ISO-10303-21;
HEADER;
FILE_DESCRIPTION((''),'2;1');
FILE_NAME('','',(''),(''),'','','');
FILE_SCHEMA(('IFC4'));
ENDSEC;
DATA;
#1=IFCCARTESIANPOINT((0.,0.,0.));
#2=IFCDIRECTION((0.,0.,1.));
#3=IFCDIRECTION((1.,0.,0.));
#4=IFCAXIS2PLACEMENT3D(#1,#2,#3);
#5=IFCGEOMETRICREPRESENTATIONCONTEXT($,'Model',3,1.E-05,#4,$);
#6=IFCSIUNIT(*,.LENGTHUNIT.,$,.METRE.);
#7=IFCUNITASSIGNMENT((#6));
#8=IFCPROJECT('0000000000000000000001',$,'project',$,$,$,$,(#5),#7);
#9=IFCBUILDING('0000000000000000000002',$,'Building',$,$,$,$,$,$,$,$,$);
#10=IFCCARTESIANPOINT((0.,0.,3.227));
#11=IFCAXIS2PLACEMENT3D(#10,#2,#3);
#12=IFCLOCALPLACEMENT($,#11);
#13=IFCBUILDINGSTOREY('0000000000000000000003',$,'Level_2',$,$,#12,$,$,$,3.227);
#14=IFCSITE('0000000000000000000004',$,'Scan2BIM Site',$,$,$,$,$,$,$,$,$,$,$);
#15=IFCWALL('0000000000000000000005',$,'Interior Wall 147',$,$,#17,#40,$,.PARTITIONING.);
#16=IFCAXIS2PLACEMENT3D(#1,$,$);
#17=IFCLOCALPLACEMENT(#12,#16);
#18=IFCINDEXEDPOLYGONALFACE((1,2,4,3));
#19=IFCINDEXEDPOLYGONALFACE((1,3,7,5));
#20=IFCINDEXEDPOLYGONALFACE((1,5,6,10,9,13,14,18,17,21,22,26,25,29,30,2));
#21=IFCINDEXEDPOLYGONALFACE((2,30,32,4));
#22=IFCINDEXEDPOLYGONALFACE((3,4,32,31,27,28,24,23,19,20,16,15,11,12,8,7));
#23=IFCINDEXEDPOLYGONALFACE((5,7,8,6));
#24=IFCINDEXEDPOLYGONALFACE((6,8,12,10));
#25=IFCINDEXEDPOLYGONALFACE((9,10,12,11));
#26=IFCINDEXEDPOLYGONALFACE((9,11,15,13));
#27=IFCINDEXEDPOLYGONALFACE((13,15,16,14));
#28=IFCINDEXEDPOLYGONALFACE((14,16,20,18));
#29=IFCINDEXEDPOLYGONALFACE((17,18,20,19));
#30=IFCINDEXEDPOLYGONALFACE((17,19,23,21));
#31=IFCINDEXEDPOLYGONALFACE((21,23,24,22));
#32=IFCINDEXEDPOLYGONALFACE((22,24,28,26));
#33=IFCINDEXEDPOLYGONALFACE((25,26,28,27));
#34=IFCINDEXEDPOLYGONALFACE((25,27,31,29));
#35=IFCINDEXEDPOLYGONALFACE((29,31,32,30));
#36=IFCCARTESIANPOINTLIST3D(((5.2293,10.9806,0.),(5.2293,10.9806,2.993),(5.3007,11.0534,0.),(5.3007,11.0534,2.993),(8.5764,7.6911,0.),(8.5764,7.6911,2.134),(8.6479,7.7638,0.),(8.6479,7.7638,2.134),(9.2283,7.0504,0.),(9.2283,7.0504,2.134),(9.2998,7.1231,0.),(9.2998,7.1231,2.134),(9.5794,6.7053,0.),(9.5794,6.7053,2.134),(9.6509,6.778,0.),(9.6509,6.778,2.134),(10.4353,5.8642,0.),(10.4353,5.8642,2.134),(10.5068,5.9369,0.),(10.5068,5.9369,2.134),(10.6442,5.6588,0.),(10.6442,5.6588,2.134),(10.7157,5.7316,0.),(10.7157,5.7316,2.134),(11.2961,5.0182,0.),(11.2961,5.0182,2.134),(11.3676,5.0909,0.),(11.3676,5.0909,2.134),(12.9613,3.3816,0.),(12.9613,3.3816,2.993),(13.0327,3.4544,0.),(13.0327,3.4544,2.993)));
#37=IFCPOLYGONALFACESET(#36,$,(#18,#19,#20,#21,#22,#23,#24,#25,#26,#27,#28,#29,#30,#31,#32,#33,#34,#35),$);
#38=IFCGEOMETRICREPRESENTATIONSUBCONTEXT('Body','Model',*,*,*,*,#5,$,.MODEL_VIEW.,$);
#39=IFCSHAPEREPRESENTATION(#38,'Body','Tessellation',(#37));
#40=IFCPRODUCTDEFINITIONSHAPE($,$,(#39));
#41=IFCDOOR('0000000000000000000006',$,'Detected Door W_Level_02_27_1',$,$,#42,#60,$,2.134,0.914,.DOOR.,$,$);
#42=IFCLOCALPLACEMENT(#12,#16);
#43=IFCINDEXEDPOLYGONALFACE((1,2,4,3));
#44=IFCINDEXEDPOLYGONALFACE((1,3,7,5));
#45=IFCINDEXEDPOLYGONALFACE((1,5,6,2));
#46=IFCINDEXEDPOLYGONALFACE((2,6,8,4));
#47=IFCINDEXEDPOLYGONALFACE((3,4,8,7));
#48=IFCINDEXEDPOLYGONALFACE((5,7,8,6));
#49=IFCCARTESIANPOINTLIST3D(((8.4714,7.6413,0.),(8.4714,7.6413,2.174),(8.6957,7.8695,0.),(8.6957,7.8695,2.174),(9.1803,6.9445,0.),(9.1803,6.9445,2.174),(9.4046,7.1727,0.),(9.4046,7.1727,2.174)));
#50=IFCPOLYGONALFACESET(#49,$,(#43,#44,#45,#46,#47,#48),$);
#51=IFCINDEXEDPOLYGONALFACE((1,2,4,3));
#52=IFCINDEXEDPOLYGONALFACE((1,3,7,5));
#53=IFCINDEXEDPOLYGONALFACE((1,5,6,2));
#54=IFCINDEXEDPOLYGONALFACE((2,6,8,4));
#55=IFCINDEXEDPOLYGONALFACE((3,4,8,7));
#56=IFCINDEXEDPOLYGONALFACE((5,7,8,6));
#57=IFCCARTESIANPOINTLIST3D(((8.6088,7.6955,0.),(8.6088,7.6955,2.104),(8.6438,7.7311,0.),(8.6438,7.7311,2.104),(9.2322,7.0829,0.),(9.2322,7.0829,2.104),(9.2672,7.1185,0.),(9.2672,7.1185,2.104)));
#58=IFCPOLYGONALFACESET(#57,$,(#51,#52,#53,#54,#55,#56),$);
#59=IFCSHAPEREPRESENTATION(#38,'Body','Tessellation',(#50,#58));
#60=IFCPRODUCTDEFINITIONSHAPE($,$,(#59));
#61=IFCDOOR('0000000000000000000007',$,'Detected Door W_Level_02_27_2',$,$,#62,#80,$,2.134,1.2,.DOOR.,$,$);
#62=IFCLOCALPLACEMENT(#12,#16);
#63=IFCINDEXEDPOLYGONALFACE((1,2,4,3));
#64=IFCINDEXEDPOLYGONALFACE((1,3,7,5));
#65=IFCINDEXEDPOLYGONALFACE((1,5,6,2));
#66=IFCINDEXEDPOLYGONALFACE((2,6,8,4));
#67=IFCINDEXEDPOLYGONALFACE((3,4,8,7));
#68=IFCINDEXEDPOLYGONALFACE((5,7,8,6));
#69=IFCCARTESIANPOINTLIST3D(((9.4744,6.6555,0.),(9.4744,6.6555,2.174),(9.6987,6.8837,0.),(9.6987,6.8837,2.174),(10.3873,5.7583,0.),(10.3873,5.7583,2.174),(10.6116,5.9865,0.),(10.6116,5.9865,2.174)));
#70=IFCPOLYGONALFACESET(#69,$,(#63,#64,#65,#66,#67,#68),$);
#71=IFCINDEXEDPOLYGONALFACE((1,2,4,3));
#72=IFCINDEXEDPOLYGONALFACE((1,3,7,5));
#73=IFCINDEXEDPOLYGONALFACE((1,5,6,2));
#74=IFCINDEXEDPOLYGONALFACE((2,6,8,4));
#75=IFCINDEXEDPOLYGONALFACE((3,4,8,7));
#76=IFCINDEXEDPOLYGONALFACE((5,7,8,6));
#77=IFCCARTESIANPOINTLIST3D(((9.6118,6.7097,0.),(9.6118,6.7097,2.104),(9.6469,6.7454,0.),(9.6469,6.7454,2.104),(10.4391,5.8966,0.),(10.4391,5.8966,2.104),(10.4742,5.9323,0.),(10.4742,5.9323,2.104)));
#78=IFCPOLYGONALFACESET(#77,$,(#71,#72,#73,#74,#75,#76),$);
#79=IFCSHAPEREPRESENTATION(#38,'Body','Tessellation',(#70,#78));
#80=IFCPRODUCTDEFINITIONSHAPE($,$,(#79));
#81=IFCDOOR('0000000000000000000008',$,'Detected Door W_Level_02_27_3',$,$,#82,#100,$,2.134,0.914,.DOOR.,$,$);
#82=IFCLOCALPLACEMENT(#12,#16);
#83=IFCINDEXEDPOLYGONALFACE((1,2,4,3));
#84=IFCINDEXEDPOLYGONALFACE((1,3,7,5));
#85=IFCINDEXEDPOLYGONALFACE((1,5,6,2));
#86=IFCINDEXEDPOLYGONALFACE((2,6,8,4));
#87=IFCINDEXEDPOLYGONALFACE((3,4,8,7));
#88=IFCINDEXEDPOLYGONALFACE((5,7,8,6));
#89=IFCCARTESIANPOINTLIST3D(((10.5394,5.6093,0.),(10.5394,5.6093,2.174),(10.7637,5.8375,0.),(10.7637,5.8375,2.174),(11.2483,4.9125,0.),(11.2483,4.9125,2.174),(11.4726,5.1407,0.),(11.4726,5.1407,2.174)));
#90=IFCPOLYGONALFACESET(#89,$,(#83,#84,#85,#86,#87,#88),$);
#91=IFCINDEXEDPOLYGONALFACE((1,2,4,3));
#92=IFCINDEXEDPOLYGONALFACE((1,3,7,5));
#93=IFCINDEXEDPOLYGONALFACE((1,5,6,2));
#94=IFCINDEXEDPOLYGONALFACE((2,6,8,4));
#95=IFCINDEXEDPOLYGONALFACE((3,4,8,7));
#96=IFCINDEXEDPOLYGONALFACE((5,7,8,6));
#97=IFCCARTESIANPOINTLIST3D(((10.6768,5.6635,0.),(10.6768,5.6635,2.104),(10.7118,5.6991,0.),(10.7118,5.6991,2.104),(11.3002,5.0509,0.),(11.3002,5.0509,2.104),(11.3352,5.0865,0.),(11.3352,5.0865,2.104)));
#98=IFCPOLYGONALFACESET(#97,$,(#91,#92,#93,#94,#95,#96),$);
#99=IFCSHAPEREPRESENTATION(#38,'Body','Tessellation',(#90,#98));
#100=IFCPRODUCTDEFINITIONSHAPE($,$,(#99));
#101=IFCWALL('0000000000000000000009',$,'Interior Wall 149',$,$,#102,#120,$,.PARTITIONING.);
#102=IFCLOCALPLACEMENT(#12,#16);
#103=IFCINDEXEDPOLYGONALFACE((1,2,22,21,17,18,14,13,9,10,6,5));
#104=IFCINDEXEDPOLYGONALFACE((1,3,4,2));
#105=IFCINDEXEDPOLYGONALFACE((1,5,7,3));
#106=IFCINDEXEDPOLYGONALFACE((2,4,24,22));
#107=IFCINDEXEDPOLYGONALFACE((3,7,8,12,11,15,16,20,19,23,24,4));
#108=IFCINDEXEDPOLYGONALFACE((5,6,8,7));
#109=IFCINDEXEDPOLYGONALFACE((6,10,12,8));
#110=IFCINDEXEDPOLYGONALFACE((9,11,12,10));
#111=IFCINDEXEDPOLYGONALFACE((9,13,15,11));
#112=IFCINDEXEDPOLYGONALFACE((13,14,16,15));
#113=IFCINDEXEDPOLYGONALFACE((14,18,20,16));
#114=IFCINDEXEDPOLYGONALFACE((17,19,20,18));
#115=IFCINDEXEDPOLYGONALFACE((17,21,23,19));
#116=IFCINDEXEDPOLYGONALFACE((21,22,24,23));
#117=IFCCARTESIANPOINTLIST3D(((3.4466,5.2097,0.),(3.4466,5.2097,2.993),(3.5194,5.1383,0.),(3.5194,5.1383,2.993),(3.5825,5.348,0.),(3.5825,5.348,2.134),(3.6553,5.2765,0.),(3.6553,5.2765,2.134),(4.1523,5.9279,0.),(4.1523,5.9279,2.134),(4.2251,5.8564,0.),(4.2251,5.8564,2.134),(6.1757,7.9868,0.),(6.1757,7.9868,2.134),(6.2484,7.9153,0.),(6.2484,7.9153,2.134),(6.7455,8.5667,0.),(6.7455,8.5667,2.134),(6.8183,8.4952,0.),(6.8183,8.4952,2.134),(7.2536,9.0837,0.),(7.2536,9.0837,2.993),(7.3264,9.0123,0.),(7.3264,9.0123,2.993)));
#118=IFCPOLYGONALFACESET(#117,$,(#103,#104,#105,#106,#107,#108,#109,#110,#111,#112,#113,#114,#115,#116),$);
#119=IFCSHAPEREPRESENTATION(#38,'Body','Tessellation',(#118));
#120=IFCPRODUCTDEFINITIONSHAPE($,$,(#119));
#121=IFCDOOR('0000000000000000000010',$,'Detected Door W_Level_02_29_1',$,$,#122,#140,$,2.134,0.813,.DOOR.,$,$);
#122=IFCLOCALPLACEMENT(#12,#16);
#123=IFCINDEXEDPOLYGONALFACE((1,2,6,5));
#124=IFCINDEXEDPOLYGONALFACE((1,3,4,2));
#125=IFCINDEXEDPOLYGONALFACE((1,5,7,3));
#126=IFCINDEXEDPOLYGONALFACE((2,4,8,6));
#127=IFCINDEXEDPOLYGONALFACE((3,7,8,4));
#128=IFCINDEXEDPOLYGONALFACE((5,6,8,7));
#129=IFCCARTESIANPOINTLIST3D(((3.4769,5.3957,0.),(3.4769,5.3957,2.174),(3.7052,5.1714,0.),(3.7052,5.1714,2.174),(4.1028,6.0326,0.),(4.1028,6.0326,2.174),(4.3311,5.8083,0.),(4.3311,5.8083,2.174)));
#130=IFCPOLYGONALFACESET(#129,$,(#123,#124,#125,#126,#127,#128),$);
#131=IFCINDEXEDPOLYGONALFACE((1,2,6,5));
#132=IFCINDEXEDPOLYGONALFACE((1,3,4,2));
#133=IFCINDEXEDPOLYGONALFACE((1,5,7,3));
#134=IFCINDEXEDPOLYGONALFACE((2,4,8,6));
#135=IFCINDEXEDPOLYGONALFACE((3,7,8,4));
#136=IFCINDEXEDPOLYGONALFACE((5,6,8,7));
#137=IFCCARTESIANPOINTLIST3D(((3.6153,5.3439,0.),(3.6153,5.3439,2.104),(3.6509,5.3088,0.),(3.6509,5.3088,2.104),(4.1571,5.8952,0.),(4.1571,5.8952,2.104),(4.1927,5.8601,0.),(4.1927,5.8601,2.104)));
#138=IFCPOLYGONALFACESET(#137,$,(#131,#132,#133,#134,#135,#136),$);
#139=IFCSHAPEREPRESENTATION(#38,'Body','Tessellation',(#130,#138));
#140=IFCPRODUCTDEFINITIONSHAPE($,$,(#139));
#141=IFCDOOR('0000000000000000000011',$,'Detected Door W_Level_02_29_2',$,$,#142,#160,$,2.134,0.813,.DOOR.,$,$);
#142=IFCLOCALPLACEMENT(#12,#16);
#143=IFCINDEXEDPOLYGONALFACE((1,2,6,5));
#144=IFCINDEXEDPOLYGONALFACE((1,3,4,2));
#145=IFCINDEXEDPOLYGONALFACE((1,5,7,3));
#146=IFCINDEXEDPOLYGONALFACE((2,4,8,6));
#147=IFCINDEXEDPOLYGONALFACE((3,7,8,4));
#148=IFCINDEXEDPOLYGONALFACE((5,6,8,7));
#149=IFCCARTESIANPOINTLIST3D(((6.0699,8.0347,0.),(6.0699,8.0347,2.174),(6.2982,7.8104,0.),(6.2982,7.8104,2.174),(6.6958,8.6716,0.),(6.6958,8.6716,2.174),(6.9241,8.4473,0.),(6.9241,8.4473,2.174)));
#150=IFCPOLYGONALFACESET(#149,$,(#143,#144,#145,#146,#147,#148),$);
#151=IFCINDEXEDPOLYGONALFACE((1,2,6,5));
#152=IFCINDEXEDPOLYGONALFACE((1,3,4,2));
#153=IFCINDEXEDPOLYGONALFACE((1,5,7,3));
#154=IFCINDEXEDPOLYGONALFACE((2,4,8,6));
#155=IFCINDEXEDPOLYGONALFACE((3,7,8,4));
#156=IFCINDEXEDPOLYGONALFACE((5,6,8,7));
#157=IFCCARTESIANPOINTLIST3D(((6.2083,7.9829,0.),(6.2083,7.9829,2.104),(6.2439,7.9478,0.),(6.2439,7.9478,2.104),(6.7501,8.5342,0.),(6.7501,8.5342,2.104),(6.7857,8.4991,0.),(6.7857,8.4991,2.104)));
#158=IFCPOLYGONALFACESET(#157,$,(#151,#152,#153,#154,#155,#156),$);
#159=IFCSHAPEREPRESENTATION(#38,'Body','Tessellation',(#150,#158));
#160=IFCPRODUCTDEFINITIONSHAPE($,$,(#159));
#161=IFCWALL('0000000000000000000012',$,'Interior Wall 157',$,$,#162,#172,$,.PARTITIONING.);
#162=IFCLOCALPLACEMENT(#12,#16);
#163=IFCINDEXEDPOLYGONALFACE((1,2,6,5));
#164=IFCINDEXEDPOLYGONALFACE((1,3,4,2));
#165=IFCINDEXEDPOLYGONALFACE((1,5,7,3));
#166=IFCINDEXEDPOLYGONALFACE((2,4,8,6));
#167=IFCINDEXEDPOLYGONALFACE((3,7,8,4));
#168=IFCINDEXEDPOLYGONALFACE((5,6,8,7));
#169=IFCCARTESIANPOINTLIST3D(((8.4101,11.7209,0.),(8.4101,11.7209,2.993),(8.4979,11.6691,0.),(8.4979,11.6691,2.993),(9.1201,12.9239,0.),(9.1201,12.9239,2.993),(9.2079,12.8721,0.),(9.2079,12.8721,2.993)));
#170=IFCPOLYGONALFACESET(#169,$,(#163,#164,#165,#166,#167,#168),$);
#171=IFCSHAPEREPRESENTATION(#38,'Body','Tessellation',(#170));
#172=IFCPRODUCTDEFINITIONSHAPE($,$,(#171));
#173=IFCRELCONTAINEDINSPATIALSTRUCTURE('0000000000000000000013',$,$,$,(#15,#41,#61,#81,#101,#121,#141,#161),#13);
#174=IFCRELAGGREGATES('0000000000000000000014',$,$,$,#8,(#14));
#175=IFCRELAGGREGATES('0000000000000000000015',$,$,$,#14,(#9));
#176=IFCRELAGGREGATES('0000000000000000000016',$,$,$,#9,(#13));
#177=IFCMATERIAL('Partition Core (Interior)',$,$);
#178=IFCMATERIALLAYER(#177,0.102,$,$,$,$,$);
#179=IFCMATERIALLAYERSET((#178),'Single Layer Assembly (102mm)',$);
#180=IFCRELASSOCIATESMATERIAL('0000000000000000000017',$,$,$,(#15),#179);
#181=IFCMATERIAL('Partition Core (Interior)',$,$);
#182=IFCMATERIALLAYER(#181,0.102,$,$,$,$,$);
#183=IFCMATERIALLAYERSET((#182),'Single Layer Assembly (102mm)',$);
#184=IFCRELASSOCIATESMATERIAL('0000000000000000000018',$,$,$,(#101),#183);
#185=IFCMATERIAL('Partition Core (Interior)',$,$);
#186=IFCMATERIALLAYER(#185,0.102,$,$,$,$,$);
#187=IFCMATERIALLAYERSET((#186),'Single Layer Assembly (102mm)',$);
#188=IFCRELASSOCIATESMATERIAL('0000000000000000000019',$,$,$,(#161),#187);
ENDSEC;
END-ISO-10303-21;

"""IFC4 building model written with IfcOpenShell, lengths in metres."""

from ifc_helpers import new_model, si_unit, frame, origin, origin_with_axes, place, context, subcontext, project, spatial, rectangle, extrude, material, layer, layer_set, element, fill, save


model = new_model("IFC4")

# Units and contexts
model_context = context("Model", 3, precision=1e-05, world=origin_with_axes())
body_context = subcontext(model_context, "Body", "Model", "MODEL_VIEW")
ifc_project = project(units=[si_unit("LENGTHUNIT", "METRE")], contexts=[model_context])

# Site, building, storey
site = spatial("IfcSite", under=ifc_project, Name="Scan2BIM Site")
building = spatial("IfcBuilding", under=site, Name="Building")
storey_placement = place(None, frame((0.0, 0.0, 3.227), z_axis=(0.0, 0.0, 1.0), x_axis=(1.0, 0.0, 0.0)))
storey = spatial("IfcBuildingStorey", under=building, at=storey_placement, Name="Level_2", Elevation=3.227)

# Walls, openings, doors
ifc_material_1 = material(Name="Partition Core (Interior)")
ifc_layer_1 = layer(ifc_material_1, 0.102)
ifc_layer_set_1 = layer_set([ifc_layer_1], Name="Single Layer Assembly (102mm)")
wall_1_placement = place(storey_placement, frame((9.131, 7.2175, 0.0), z_axis=(0.0, 0.0, 1.0), x_axis=(0.713214, -0.700946, 0.0)))
wall_1 = element("IfcWall", 1, at=wall_1_placement, inside=storey, material=ifc_layer_set_1, Name="Interior Wall 147", PredefinedType="PARTITIONING", context=body_context, shape_type="SweptSolid", body=[
    extrude(rectangle(XDim=10.8411, YDim=0.102), origin(), (0.0, 0.0, 1.0), 2.993),
])
opening_1_placement = place(None, frame((8.938, 7.407, 3.227), z_axis=(0.0, 0.0, 1.0), x_axis=(0.713214, -0.700946, 0.0)))
opening_1 = element("IfcOpeningElement", 2, at=opening_1_placement, cuts=wall_1, PredefinedType="OPENING", context=body_context, shape_type="SweptSolid", body=[
    extrude(rectangle(XDim=0.914, YDim=0.202), origin(), (0.0, 0.0, 1.0), 2.134),
])
opening_2_placement = place(None, frame((10.043, 6.321, 3.227), z_axis=(0.0, 0.0, 1.0), x_axis=(0.713214, -0.700946, 0.0)))
opening_2 = element("IfcOpeningElement", 3, at=opening_2_placement, cuts=wall_1, PredefinedType="OPENING", context=body_context, shape_type="SweptSolid", body=[
    extrude(rectangle(XDim=1.2, YDim=0.202), origin(), (0.0, 0.0, 1.0), 2.134),
])
opening_3_placement = place(None, frame((11.006, 5.375, 3.227), z_axis=(0.0, 0.0, 1.0), x_axis=(0.713214, -0.700946, 0.0)))
opening_3 = element("IfcOpeningElement", 4, at=opening_3_placement, cuts=wall_1, PredefinedType="OPENING", context=body_context, shape_type="SweptSolid", body=[
    extrude(rectangle(XDim=0.914, YDim=0.202), origin(), (0.0, 0.0, 1.0), 2.134),
])
door_1_placement = place(opening_1_placement, frame((0.0, 0.0, 0.0), z_axis=(0.0, 0.0, 1.0), x_axis=(1.0, 0.0, 0.0)))
door_1 = element("IfcDoor", 5, at=door_1_placement, inside=storey, Name="Detected Door W_Level_02_27_1", OverallHeight=2.134, OverallWidth=0.914, PredefinedType="DOOR", context=body_context, shape_type="SweptSolid", body=[
    extrude(rectangle(XDim=0.994, YDim=0.32), origin(), (0.0, 0.0, 1.0), 2.174),
    extrude(rectangle(XDim=0.874, YDim=0.05), origin(), (0.0, 0.0, 1.0), 2.104),
])
fill(opening_1, door_1)
door_2_placement = place(opening_2_placement, frame((0.0, 0.0, 0.0), z_axis=(0.0, 0.0, 1.0), x_axis=(1.0, 0.0, 0.0)))
door_2 = element("IfcDoor", 6, at=door_2_placement, inside=storey, Name="Detected Door W_Level_02_27_2", OverallHeight=2.134, OverallWidth=1.2, PredefinedType="DOOR", context=body_context, shape_type="SweptSolid", body=[
    extrude(rectangle(XDim=1.28, YDim=0.32), origin(), (0.0, 0.0, 1.0), 2.174),
    extrude(rectangle(XDim=1.16, YDim=0.05), origin(), (0.0, 0.0, 1.0), 2.104),
])
fill(opening_2, door_2)
door_3_placement = place(opening_3_placement, frame((0.0, 0.0, 0.0), z_axis=(0.0, 0.0, 1.0), x_axis=(1.0, 0.0, 0.0)))
door_3 = element("IfcDoor", 7, at=door_3_placement, inside=storey, Name="Detected Door W_Level_02_27_3", OverallHeight=2.134, OverallWidth=0.914, PredefinedType="DOOR", context=body_context, shape_type="SweptSolid", body=[
    extrude(rectangle(XDim=0.994, YDim=0.32), origin(), (0.0, 0.0, 1.0), 2.174),
    extrude(rectangle(XDim=0.874, YDim=0.05), origin(), (0.0, 0.0, 1.0), 2.104),
])
fill(opening_3, door_3)
ifc_material_2 = material(Name="Partition Core (Interior)")
ifc_layer_2 = layer(ifc_material_2, 0.102)
ifc_layer_set_2 = layer_set([ifc_layer_2], Name="Single Layer Assembly (102mm)")
wall_2_placement = place(storey_placement, frame((5.3865, 7.111, 0.0), z_axis=(0.0, 0.0, 1.0), x_axis=(0.700912, 0.713248, 0.0)))
wall_2 = element("IfcWall", 8, at=wall_2_placement, inside=storey, material=ifc_layer_set_2, Name="Interior Wall 149", PredefinedType="PARTITIONING", context=body_context, shape_type="SweptSolid", body=[
    extrude(rectangle(XDim=5.4315, YDim=0.102), origin(), (0.0, 0.0, 1.0), 2.993),
])
opening_4_placement = place(None, frame((3.904, 5.602, 3.227), z_axis=(0.0, 0.0, 1.0), x_axis=(0.700912, 0.713248, 0.0)))
opening_4 = element("IfcOpeningElement", 9, at=opening_4_placement, cuts=wall_2, PredefinedType="OPENING", context=body_context, shape_type="SweptSolid", body=[
    extrude(rectangle(XDim=0.813, YDim=0.202), origin(), (0.0, 0.0, 1.0), 2.134),
])
opening_5_placement = place(None, frame((6.497, 8.241, 3.227), z_axis=(0.0, 0.0, 1.0), x_axis=(0.700912, 0.713248, 0.0)))
opening_5 = element("IfcOpeningElement", 10, at=opening_5_placement, cuts=wall_2, PredefinedType="OPENING", context=body_context, shape_type="SweptSolid", body=[
    extrude(rectangle(XDim=0.813, YDim=0.202), origin(), (0.0, 0.0, 1.0), 2.134),
])
door_4_placement = place(opening_4_placement, frame((0.0, 0.0, 0.0), z_axis=(0.0, 0.0, 1.0), x_axis=(1.0, 0.0, 0.0)))
door_4 = element("IfcDoor", 11, at=door_4_placement, inside=storey, Name="Detected Door W_Level_02_29_1", OverallHeight=2.134, OverallWidth=0.813, PredefinedType="DOOR", context=body_context, shape_type="SweptSolid", body=[
    extrude(rectangle(XDim=0.893, YDim=0.32), origin(), (0.0, 0.0, 1.0), 2.174),
    extrude(rectangle(XDim=0.773, YDim=0.05), origin(), (0.0, 0.0, 1.0), 2.104),
])
fill(opening_4, door_4)
door_5_placement = place(opening_5_placement, frame((0.0, 0.0, 0.0), z_axis=(0.0, 0.0, 1.0), x_axis=(1.0, 0.0, 0.0)))
door_5 = element("IfcDoor", 12, at=door_5_placement, inside=storey, Name="Detected Door W_Level_02_29_2", OverallHeight=2.134, OverallWidth=0.813, PredefinedType="DOOR", context=body_context, shape_type="SweptSolid", body=[
    extrude(rectangle(XDim=0.893, YDim=0.32), origin(), (0.0, 0.0, 1.0), 2.174),
    extrude(rectangle(XDim=0.773, YDim=0.05), origin(), (0.0, 0.0, 1.0), 2.104),
])
fill(opening_5, door_5)

# Wall
ifc_material_3 = material(Name="Partition Core (Interior)")
ifc_layer_3 = layer(ifc_material_3, 0.102)
ifc_layer_set_3 = layer_set([ifc_layer_3], Name="Single Layer Assembly (102mm)")
wall_3_placement = place(storey_placement, frame((8.809, 12.2965, 0.0), z_axis=(0.0, 0.0, 1.0), x_axis=(-0.508271, -0.861197, 0.0)))
element("IfcWall", 13, at=wall_3_placement, inside=storey, material=ifc_layer_set_3, Name="Interior Wall 157", PredefinedType="PARTITIONING", context=body_context, shape_type="SweptSolid", body=[
    extrude(rectangle(XDim=1.3969, YDim=0.102), origin(), (0.0, 0.0, 1.0), 2.993),
])

save(model, "model.ifc")
